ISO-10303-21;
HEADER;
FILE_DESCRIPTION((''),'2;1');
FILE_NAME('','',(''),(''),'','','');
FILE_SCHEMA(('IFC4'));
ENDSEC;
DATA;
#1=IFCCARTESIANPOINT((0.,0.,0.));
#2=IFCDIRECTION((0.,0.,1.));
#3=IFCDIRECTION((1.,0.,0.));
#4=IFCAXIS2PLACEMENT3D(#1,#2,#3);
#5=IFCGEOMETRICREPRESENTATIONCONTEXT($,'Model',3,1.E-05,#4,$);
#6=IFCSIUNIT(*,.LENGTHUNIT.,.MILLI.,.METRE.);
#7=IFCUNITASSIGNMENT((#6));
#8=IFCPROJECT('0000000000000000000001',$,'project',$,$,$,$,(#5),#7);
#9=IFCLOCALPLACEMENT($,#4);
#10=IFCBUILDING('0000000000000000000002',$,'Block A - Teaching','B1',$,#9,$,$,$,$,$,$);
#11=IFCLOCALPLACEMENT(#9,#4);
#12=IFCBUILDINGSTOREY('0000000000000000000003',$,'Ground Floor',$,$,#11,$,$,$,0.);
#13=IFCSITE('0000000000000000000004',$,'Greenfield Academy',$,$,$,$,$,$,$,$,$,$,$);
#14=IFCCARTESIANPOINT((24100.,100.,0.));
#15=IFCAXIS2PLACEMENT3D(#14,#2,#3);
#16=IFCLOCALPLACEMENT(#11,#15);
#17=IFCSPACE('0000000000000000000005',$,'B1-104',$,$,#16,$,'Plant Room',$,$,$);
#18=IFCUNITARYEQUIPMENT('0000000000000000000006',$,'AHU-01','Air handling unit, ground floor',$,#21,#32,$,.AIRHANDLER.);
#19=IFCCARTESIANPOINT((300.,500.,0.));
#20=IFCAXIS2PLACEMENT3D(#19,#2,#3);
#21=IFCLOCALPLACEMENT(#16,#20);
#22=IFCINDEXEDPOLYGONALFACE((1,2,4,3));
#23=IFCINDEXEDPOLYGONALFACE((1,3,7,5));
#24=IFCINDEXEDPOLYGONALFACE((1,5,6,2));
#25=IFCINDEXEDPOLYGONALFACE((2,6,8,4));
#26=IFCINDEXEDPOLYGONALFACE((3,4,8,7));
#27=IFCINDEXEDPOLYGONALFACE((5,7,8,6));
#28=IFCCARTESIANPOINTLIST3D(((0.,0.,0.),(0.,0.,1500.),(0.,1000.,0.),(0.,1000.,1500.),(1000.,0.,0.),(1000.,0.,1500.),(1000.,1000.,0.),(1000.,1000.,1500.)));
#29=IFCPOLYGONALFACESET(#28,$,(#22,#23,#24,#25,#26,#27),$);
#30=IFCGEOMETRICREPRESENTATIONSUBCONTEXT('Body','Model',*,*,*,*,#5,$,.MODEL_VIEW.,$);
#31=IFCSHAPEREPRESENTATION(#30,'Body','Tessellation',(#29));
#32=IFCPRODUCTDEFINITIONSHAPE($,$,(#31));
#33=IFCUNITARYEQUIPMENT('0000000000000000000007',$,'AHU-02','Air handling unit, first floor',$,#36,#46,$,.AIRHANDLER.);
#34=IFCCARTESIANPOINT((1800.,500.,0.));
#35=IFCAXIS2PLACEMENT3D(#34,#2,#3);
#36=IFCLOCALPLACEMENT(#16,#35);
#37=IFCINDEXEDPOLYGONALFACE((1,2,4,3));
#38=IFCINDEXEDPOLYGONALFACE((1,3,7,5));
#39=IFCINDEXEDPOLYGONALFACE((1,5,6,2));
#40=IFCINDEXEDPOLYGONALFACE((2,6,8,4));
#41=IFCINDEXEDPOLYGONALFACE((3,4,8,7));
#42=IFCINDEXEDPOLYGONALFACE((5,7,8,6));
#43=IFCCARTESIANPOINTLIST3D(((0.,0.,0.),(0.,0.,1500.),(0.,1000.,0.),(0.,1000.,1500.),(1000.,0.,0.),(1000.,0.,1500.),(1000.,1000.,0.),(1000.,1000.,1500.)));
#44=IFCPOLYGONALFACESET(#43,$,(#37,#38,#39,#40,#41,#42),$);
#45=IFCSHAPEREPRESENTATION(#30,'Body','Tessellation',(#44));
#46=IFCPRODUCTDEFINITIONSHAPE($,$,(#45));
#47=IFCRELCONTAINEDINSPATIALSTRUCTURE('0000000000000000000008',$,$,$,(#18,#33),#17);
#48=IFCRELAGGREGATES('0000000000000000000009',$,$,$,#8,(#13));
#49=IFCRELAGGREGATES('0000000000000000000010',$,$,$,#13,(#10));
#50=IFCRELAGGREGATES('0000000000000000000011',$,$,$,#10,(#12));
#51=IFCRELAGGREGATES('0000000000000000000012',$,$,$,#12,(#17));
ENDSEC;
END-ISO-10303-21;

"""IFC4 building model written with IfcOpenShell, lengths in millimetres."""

from ifc_helpers import new_model, si_unit, frame, origin_with_axes, place, context, subcontext, project, spatial, indexed_curve, outline, extrude, element, save


model = new_model("IFC4")

# Units and contexts
model_context = context("Model", 3, precision=1e-05, world=origin_with_axes())
body_context = subcontext(model_context, "Body", "Model", "MODEL_VIEW")
ifc_project = project(units=[si_unit("LENGTHUNIT", "METRE", prefix="MILLI")], contexts=[model_context])

# Site, building, storey
site = spatial("IfcSite", under=ifc_project, Name="Greenfield Academy")
building_placement = place(None, origin_with_axes())
building = spatial("IfcBuilding", under=site, at=building_placement, Name="Block A - Teaching", Description="B1")
storey_placement = place(building_placement, origin_with_axes())
storey = spatial("IfcBuildingStorey", under=building, at=storey_placement, Name="Ground Floor", Elevation=0.0)

# Shared definitions
space_1_placement = place(storey_placement, frame((24100.0, 100.0, 0.0), z_axis=(0.0, 0.0, 1.0), x_axis=(1.0, 0.0, 0.0)))
space_1 = spatial("IfcSpace", under=storey, at=space_1_placement, Name="B1-104", LongName="Plant Room")

# Unitary equipment
for number, where, z_axis, x_axis, name, description in (
    (1, (300.0, 500.0, 0.0), (0.0, 0.0, 1.0), (1.0, 0.0, 0.0), "AHU-01", "Air handling unit, ground floor"),
    (2, (1800.0, 500.0, 0.0), (0.0, 0.0, 1.0), (1.0, 0.0, 0.0), "AHU-02", "Air handling unit, first floor"),
):
    element("IfcUnitaryEquipment", number, at=place(space_1_placement, frame(where, z_axis=z_axis, x_axis=x_axis)), inside=space_1, Name=name, Description=description, PredefinedType="AIRHANDLER", context=body_context, shape_type="SweptSolid", body=[
        extrude(outline(indexed_curve([(0.0, 0.0), (0.0, 1000.0), (1000.0, 1000.0), (1000.0, 0.0), (0.0, 0.0)], self_intersect=False)), origin_with_axes(), (0.0, 0.0, 1.0), 1500.0),
    ])

save(model, "model.ifc")
